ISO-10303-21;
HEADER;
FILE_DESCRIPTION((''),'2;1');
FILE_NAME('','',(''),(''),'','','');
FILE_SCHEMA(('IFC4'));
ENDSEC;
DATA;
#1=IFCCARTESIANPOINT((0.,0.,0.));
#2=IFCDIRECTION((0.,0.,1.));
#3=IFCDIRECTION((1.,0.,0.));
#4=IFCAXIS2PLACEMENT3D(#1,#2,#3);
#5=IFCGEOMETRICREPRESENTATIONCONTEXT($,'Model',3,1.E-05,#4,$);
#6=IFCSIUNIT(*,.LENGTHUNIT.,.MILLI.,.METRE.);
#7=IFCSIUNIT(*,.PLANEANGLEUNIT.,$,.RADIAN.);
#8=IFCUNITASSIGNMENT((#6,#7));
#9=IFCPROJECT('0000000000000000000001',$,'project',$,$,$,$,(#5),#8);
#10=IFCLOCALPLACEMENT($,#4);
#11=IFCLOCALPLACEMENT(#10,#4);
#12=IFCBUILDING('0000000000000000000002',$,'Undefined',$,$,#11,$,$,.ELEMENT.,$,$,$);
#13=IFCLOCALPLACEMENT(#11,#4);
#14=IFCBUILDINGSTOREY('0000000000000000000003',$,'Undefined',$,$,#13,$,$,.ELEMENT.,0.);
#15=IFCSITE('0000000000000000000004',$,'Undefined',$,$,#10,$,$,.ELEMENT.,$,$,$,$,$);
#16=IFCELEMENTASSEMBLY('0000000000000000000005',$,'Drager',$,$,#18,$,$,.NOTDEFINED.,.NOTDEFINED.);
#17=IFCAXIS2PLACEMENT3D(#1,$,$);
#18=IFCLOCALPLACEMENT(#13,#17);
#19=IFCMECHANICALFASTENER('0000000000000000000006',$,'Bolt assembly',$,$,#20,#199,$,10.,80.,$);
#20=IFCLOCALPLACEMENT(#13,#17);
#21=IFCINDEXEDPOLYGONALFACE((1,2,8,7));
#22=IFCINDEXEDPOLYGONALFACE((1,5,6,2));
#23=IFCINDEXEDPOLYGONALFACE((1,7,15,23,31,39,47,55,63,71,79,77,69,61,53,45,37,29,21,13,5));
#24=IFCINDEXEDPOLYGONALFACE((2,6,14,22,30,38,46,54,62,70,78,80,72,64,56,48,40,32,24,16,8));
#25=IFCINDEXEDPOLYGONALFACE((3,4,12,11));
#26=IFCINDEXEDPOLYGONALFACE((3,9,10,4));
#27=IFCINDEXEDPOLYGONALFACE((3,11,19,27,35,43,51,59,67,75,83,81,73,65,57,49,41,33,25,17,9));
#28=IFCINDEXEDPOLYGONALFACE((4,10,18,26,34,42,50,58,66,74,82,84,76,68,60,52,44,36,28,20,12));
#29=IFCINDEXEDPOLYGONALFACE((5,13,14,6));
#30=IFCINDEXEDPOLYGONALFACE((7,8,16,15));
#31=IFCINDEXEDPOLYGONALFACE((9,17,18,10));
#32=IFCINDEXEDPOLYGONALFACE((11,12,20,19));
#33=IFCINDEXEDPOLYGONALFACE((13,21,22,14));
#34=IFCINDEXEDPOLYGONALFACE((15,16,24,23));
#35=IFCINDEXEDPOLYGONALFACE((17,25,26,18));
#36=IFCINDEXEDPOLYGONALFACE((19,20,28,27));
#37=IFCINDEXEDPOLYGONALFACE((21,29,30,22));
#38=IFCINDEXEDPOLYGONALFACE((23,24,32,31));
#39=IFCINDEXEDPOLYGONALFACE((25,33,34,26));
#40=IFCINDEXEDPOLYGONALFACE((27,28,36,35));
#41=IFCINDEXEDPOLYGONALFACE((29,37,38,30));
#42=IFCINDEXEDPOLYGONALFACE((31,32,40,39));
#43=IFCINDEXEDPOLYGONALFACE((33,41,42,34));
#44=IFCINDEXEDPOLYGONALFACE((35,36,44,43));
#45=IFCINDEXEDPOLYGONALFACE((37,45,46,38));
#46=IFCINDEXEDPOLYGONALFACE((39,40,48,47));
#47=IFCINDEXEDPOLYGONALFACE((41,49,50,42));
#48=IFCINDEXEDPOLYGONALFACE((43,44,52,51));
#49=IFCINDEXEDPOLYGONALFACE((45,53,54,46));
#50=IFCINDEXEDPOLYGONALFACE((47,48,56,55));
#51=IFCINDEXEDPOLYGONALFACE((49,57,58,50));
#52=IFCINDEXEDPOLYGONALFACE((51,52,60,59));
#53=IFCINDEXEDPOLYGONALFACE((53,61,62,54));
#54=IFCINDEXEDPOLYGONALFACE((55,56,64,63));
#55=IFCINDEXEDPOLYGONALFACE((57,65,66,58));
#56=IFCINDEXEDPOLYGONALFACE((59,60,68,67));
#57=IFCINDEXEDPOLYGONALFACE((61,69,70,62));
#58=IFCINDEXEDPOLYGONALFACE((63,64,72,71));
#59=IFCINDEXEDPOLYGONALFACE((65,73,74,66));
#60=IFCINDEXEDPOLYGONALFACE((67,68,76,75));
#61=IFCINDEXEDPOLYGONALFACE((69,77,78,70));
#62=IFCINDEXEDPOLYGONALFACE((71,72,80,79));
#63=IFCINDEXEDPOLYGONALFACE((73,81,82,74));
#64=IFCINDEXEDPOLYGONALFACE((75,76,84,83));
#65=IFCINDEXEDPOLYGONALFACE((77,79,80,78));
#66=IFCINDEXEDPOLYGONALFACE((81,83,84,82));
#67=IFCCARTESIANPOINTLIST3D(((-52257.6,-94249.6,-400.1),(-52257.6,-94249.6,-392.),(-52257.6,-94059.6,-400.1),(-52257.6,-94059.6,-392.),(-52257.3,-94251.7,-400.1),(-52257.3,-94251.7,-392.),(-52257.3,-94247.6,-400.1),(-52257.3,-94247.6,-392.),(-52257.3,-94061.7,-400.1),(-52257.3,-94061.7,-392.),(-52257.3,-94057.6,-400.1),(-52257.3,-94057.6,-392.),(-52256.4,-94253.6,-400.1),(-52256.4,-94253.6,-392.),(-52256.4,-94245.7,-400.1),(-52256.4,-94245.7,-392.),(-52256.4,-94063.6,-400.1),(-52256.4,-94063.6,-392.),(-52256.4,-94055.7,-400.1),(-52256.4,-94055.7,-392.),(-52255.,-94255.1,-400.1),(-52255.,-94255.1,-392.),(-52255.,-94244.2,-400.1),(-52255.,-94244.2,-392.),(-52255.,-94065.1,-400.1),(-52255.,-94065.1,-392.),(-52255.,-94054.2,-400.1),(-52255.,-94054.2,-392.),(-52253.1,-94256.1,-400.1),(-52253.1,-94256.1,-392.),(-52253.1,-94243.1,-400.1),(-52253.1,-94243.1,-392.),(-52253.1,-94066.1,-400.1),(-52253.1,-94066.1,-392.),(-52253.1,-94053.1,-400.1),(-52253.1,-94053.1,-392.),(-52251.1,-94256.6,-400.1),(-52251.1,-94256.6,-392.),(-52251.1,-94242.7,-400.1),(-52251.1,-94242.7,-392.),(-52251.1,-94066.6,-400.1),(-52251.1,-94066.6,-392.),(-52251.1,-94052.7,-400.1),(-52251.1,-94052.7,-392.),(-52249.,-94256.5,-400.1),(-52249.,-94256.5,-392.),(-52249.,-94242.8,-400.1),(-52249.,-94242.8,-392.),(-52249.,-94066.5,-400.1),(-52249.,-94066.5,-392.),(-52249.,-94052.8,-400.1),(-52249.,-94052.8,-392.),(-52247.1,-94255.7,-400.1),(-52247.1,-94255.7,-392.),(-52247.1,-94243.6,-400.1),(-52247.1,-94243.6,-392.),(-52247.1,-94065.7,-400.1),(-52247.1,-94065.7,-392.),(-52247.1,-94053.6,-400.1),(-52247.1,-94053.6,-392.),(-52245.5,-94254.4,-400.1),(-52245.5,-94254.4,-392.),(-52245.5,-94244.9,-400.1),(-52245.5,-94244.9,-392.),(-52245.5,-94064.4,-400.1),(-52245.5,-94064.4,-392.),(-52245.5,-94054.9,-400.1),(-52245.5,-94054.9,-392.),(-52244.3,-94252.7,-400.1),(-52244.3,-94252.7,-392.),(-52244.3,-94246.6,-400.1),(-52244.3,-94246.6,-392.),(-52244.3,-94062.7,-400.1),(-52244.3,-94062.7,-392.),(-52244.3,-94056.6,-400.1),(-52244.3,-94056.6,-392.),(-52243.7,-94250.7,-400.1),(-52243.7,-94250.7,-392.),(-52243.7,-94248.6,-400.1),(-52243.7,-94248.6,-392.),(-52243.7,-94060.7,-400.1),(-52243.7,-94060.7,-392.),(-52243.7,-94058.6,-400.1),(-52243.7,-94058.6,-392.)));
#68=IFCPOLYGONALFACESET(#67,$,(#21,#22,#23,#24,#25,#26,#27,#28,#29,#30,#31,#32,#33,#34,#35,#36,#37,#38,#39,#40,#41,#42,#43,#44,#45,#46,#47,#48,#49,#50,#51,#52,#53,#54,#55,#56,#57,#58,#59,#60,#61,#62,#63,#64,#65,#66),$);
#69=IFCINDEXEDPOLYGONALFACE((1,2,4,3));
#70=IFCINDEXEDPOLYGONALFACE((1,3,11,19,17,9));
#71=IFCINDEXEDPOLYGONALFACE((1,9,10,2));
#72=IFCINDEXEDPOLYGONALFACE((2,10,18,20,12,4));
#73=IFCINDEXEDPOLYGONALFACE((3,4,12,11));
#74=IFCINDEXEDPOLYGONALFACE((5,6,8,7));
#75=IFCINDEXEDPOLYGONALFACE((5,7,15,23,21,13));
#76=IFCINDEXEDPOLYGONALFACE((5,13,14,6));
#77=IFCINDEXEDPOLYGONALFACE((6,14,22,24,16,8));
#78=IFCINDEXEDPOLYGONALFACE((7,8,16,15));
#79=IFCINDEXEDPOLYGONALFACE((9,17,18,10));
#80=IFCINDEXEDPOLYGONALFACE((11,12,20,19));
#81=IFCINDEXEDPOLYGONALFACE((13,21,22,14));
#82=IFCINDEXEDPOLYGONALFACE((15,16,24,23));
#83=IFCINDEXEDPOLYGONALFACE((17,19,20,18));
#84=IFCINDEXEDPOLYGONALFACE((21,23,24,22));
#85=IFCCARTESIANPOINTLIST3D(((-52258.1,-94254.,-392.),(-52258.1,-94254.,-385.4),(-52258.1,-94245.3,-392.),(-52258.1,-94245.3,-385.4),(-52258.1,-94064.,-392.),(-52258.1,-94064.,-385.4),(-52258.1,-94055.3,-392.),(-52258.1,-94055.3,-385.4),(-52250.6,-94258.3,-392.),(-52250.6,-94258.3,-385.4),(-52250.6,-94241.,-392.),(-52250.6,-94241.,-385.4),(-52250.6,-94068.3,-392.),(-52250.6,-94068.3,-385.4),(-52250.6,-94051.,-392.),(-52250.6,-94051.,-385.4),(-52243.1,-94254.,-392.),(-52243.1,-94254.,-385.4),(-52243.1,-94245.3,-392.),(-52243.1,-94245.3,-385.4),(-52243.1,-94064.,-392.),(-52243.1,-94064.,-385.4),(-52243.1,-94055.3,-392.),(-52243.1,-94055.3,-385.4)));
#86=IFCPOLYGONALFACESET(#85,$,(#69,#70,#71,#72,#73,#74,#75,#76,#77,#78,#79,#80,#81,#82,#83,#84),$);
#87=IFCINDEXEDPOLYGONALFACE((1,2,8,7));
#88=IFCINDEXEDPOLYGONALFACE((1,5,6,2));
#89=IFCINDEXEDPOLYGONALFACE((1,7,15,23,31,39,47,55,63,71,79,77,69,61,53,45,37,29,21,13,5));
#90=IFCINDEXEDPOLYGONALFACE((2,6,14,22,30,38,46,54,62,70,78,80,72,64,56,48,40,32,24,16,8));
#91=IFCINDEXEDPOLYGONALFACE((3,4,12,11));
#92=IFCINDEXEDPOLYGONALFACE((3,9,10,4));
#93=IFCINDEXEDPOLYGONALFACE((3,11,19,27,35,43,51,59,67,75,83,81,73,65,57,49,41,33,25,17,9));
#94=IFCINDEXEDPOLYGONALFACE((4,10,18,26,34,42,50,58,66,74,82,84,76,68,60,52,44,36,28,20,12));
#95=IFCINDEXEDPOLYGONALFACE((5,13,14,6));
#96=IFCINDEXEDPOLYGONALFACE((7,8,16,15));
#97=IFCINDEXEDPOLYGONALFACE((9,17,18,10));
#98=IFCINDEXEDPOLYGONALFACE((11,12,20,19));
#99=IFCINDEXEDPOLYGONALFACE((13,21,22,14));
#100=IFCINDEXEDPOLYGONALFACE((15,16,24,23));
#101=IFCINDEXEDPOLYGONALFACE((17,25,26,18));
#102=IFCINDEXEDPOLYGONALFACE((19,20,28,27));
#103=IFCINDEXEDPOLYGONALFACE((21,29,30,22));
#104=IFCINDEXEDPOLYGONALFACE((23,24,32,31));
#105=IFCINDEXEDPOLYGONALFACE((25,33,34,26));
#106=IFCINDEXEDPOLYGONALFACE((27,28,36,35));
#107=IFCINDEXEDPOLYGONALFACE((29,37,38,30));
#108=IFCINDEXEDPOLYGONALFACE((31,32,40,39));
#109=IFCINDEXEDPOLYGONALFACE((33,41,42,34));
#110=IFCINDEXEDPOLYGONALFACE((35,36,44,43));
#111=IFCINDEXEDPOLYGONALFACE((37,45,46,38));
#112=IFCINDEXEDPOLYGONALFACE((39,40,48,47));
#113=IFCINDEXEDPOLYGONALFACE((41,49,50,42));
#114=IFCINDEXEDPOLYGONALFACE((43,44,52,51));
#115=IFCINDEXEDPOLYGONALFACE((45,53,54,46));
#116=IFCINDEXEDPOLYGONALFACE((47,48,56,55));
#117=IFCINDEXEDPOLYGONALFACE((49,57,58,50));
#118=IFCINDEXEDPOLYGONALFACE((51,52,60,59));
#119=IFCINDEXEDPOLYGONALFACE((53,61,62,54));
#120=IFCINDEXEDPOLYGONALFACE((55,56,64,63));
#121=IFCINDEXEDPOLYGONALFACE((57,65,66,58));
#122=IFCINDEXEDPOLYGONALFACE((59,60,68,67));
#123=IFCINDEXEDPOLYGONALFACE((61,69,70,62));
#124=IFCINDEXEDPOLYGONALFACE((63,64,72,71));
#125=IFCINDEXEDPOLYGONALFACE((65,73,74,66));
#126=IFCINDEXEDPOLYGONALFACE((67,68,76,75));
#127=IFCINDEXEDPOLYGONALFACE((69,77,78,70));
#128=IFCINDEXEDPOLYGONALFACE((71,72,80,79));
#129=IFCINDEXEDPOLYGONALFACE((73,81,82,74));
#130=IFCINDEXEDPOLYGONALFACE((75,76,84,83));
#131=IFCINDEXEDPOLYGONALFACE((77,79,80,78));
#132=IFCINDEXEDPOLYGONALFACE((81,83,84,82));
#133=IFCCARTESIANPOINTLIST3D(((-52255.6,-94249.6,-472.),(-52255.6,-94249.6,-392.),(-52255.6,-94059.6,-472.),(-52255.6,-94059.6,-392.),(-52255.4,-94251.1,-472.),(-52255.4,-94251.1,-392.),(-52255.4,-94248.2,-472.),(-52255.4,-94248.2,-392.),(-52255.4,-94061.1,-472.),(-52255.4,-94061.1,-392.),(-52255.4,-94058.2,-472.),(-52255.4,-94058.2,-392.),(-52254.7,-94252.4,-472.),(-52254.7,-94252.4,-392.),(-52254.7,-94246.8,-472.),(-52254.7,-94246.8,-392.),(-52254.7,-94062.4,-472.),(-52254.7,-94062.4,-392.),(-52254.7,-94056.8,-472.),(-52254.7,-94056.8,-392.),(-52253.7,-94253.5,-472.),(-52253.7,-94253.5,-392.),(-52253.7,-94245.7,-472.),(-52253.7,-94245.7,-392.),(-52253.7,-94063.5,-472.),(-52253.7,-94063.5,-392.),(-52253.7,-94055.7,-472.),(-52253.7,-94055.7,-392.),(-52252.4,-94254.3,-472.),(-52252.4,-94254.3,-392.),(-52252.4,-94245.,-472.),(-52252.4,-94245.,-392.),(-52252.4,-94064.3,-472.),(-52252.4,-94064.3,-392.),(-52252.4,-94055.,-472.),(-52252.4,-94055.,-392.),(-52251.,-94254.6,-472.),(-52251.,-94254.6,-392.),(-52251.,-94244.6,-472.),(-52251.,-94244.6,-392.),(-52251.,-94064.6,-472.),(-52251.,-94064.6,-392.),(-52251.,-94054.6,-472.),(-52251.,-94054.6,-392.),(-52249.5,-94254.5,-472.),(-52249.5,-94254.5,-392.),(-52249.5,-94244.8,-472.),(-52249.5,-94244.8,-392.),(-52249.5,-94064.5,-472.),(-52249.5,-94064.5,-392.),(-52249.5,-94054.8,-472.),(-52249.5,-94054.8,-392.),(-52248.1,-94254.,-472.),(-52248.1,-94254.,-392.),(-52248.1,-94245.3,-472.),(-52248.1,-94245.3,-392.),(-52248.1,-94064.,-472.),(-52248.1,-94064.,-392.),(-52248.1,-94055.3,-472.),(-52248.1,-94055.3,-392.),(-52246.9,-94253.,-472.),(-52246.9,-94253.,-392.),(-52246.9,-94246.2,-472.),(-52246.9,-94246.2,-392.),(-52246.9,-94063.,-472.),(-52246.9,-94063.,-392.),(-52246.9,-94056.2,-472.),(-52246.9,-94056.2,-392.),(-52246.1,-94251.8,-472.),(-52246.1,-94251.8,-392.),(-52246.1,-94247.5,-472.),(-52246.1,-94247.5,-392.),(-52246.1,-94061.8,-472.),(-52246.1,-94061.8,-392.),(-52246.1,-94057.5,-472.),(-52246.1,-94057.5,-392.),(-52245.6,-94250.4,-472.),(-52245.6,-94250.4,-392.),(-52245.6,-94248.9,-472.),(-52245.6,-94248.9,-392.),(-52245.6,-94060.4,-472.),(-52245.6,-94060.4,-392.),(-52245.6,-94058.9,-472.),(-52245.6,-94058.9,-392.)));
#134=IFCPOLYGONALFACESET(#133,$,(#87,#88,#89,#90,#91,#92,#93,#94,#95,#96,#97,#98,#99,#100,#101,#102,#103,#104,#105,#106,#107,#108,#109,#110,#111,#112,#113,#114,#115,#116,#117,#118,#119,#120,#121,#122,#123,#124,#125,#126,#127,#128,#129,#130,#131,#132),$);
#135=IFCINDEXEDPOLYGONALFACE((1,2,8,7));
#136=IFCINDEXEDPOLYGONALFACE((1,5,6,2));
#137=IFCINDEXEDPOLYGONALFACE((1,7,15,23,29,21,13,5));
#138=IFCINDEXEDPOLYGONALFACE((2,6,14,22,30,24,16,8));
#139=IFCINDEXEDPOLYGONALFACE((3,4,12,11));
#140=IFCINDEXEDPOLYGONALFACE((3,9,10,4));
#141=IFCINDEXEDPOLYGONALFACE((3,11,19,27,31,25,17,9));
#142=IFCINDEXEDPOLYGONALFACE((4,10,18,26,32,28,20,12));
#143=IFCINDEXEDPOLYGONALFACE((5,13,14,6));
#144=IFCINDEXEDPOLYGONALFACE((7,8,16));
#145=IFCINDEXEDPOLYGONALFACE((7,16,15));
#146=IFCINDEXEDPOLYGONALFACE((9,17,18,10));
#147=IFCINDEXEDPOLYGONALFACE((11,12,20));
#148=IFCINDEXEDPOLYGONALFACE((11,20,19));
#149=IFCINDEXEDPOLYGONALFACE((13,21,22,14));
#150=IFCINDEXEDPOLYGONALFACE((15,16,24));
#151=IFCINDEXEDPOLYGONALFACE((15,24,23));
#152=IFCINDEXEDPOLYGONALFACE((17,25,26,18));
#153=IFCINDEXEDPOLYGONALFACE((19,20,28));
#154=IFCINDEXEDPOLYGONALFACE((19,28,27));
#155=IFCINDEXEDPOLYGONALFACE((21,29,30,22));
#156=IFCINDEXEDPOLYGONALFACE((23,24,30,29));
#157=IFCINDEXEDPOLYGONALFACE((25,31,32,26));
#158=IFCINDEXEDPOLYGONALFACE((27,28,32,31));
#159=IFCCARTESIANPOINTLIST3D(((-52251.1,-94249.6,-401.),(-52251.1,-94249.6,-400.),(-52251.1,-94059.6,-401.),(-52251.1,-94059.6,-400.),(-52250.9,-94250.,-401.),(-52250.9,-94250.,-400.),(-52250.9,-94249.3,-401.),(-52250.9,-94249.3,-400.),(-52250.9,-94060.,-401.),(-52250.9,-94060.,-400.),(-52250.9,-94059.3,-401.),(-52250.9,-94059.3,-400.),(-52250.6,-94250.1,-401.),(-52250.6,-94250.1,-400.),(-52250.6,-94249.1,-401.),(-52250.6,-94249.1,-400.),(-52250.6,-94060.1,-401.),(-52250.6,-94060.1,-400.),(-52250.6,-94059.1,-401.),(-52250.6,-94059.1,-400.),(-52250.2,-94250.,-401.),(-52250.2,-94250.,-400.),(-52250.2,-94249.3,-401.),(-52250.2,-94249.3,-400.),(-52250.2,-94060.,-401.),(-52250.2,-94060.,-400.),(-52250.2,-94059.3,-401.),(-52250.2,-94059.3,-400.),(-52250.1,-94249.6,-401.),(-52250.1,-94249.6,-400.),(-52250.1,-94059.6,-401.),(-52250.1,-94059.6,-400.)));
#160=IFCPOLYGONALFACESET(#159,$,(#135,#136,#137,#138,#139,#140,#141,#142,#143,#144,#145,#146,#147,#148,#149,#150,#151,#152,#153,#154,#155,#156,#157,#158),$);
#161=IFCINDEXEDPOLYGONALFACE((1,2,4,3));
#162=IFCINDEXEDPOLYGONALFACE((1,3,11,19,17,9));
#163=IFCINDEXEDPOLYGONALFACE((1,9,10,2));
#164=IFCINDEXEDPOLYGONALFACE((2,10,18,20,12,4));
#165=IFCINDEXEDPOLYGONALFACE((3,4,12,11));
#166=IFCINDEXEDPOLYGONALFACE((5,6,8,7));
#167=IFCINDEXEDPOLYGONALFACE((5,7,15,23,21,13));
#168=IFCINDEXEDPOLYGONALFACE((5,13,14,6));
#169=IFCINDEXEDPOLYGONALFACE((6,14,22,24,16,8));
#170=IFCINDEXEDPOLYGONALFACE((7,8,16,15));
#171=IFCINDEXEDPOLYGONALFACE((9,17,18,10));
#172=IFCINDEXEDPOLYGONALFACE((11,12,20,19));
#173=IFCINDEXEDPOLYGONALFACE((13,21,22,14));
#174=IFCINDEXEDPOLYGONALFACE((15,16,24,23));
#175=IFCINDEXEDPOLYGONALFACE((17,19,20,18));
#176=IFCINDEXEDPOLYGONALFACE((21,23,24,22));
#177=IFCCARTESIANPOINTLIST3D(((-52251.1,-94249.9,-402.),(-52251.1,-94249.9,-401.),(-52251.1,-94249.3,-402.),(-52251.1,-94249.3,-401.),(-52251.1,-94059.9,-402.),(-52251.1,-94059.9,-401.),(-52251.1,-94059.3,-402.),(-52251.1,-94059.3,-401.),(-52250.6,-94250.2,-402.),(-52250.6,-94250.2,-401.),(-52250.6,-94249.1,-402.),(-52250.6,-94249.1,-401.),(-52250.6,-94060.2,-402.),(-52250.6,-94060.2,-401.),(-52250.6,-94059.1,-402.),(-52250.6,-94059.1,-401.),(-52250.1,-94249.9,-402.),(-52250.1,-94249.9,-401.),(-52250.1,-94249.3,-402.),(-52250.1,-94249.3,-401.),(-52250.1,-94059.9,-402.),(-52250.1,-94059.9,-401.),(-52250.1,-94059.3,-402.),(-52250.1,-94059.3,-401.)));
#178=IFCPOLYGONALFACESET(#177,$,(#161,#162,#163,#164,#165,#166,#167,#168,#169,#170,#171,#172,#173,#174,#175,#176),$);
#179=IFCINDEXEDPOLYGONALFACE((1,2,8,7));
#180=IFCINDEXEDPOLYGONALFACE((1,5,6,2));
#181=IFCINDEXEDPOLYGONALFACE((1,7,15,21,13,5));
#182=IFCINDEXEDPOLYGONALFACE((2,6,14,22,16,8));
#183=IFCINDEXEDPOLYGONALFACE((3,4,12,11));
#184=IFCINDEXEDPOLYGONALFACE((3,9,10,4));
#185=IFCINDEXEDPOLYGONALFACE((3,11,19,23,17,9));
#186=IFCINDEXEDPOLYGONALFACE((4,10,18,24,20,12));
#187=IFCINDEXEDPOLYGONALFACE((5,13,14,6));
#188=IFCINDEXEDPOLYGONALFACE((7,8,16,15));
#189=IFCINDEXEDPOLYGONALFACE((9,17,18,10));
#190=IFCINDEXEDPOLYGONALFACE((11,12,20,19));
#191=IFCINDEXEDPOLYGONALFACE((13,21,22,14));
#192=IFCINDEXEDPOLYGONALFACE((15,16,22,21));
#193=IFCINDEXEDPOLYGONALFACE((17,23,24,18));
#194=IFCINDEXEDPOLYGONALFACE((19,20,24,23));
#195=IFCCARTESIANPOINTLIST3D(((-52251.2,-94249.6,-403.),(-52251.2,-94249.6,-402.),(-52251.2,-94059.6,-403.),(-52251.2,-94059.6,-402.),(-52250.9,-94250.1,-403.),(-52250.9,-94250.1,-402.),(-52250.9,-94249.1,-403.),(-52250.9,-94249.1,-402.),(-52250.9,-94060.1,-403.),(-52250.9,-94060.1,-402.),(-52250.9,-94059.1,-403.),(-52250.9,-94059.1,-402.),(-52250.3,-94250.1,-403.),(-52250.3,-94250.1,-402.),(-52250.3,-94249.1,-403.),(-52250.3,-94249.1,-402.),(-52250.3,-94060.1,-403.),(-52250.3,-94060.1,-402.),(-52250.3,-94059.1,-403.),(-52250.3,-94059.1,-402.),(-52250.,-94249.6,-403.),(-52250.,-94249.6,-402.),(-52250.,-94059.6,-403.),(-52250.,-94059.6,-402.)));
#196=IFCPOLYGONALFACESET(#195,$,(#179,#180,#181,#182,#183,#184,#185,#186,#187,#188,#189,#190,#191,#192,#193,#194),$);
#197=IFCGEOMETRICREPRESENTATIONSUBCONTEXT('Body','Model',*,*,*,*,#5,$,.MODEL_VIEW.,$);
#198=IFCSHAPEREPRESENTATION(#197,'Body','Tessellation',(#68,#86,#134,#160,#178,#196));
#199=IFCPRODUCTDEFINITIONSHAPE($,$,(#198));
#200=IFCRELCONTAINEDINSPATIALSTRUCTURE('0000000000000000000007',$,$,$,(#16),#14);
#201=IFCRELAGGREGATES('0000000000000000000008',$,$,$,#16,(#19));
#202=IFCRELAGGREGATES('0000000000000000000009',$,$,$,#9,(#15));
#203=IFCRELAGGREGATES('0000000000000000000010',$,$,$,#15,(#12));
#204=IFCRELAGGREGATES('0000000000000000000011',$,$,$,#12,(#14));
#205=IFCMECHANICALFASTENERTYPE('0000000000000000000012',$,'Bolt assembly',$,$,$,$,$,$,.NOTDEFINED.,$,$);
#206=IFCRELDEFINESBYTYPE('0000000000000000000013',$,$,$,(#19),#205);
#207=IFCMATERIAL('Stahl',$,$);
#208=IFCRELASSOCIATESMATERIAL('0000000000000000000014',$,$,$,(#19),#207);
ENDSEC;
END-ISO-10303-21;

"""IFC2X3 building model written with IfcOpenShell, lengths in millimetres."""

from ifc_helpers import new_model, si_unit, frame, origin_with_axes, origin_2d_with_axis, place, context, subcontext, project, spatial, polyline, circle, outline, extrude, source, transform, mapped, material, type_object, element, aggregate, save


model = new_model("IFC2X3")

# Units and contexts
model_context = context("Model", 3, precision=1e-05, world=origin_with_axes())
body_context = subcontext(model_context, "Body", "Model", "MODEL_VIEW")
ifc_project = project(units=[si_unit("LENGTHUNIT", "METRE", prefix="MILLI"), si_unit("PLANEANGLEUNIT", "RADIAN")], contexts=[model_context])

# Site, building, storey
site_placement = place(None, origin_with_axes())
site = spatial("IfcSite", under=ifc_project, at=site_placement, Name="Undefined", CompositionType="ELEMENT")
building_placement = place(site_placement, origin_with_axes())
building = spatial("IfcBuilding", under=site, at=building_placement, Name="Undefined", CompositionType="ELEMENT")
storey_placement = place(building_placement, origin_with_axes())
storey = spatial("IfcBuildingStorey", under=building, at=storey_placement, Name="Undefined", CompositionType="ELEMENT", Elevation=0.0)

# Element assembly, mechanical fastener
assembly_1_placement = place(storey_placement, origin_with_axes())
assembly_1 = element("IfcElementAssembly", 1, at=assembly_1_placement, inside=storey, Name="Drager", AssemblyPlace="NOTDEFINED", PredefinedType="NOTDEFINED")
mechanical_fastener_type = type_object("IfcMechanicalFastenerType", Name="Bolt assembly")
ifc_material_1 = material(Name="Stahl")
shared_shape_1 = source(origin_with_axes(), body_context, "Body", "SweptSolid", [
    extrude(circle(Radius=7.0, at=origin_2d_with_axis()), frame((0.0, 0.0, 0.0), z_axis=(0.0, 1.0, 0.0), x_axis=(1.0, 0.0, 0.0)), (0.0, 0.0, 1.0), 8.1),
    extrude(outline(polyline([(7.5, -4.3), (7.5, 4.3), (0.0, 8.7), (-7.5, 4.3), (-7.5, -4.3), (0.0, -8.7), (7.5, -4.3)])), frame((0.0, -6.6, 0.0), z_axis=(0.0, 1.0, 0.0), x_axis=(1.0, 0.0, 0.0)), (0.0, 0.0, 1.0), 6.6),
    extrude(circle(Radius=5.0, at=origin_2d_with_axis()), frame((0.0, 0.0, 0.0), z_axis=(0.0, 1.0, 0.0), x_axis=(1.0, 0.0, 0.0)), (0.0, 0.0, 1.0), 80.0),
    extrude(circle(Radius=0.5, at=origin_2d_with_axis()), frame((0.0, 8.0, 0.0), z_axis=(0.0, 1.0, 0.0), x_axis=(1.0, 0.0, 0.0)), (0.0, 0.0, 1.0), 1.0),
    extrude(outline(polyline([(0.5, -0.3), (0.5, 0.3), (0.0, 0.6), (-0.5, 0.3), (-0.5, -0.3), (0.0, -0.6), (0.5, -0.3)])), frame((0.0, 9.0, 0.0), z_axis=(0.0, 1.0, 0.0), x_axis=(1.0, 0.0, 0.0)), (0.0, 0.0, 1.0), 1.0),
    extrude(outline(polyline([(0.6, 0.0), (0.3, 0.5), (-0.3, 0.5), (-0.6, 0.0), (-0.3, -0.5), (0.3, -0.5), (0.6, 0.0)])), frame((0.0, 10.0, 0.0), z_axis=(0.0, 1.0, 0.0), x_axis=(1.0, 0.0, 0.0)), (0.0, 0.0, 1.0), 1.0),
])
mechanical_fastener_1_placement = place(assembly_1_placement, frame((-52250.6, -94154.6, -392.0), z_axis=(0.0, -1.0, 0.0), x_axis=(-1.0, 0.0, 0.0)))
mechanical_fastener_1 = element("IfcMechanicalFastener", 2, at=mechanical_fastener_1_placement, type_object=mechanical_fastener_type, material=ifc_material_1, Name="Bolt assembly", NominalDiameter=10.0, NominalLength=80.0, context=body_context, shape_type="MappedRepresentation", body=[
    mapped(shared_shape_1, transform((0.0, 0.0, -95.0))),
    mapped(shared_shape_1, transform((0.0, 0.0, 95.0))),
])
aggregate(assembly_1, [mechanical_fastener_1])

save(model, "model.ifc")
